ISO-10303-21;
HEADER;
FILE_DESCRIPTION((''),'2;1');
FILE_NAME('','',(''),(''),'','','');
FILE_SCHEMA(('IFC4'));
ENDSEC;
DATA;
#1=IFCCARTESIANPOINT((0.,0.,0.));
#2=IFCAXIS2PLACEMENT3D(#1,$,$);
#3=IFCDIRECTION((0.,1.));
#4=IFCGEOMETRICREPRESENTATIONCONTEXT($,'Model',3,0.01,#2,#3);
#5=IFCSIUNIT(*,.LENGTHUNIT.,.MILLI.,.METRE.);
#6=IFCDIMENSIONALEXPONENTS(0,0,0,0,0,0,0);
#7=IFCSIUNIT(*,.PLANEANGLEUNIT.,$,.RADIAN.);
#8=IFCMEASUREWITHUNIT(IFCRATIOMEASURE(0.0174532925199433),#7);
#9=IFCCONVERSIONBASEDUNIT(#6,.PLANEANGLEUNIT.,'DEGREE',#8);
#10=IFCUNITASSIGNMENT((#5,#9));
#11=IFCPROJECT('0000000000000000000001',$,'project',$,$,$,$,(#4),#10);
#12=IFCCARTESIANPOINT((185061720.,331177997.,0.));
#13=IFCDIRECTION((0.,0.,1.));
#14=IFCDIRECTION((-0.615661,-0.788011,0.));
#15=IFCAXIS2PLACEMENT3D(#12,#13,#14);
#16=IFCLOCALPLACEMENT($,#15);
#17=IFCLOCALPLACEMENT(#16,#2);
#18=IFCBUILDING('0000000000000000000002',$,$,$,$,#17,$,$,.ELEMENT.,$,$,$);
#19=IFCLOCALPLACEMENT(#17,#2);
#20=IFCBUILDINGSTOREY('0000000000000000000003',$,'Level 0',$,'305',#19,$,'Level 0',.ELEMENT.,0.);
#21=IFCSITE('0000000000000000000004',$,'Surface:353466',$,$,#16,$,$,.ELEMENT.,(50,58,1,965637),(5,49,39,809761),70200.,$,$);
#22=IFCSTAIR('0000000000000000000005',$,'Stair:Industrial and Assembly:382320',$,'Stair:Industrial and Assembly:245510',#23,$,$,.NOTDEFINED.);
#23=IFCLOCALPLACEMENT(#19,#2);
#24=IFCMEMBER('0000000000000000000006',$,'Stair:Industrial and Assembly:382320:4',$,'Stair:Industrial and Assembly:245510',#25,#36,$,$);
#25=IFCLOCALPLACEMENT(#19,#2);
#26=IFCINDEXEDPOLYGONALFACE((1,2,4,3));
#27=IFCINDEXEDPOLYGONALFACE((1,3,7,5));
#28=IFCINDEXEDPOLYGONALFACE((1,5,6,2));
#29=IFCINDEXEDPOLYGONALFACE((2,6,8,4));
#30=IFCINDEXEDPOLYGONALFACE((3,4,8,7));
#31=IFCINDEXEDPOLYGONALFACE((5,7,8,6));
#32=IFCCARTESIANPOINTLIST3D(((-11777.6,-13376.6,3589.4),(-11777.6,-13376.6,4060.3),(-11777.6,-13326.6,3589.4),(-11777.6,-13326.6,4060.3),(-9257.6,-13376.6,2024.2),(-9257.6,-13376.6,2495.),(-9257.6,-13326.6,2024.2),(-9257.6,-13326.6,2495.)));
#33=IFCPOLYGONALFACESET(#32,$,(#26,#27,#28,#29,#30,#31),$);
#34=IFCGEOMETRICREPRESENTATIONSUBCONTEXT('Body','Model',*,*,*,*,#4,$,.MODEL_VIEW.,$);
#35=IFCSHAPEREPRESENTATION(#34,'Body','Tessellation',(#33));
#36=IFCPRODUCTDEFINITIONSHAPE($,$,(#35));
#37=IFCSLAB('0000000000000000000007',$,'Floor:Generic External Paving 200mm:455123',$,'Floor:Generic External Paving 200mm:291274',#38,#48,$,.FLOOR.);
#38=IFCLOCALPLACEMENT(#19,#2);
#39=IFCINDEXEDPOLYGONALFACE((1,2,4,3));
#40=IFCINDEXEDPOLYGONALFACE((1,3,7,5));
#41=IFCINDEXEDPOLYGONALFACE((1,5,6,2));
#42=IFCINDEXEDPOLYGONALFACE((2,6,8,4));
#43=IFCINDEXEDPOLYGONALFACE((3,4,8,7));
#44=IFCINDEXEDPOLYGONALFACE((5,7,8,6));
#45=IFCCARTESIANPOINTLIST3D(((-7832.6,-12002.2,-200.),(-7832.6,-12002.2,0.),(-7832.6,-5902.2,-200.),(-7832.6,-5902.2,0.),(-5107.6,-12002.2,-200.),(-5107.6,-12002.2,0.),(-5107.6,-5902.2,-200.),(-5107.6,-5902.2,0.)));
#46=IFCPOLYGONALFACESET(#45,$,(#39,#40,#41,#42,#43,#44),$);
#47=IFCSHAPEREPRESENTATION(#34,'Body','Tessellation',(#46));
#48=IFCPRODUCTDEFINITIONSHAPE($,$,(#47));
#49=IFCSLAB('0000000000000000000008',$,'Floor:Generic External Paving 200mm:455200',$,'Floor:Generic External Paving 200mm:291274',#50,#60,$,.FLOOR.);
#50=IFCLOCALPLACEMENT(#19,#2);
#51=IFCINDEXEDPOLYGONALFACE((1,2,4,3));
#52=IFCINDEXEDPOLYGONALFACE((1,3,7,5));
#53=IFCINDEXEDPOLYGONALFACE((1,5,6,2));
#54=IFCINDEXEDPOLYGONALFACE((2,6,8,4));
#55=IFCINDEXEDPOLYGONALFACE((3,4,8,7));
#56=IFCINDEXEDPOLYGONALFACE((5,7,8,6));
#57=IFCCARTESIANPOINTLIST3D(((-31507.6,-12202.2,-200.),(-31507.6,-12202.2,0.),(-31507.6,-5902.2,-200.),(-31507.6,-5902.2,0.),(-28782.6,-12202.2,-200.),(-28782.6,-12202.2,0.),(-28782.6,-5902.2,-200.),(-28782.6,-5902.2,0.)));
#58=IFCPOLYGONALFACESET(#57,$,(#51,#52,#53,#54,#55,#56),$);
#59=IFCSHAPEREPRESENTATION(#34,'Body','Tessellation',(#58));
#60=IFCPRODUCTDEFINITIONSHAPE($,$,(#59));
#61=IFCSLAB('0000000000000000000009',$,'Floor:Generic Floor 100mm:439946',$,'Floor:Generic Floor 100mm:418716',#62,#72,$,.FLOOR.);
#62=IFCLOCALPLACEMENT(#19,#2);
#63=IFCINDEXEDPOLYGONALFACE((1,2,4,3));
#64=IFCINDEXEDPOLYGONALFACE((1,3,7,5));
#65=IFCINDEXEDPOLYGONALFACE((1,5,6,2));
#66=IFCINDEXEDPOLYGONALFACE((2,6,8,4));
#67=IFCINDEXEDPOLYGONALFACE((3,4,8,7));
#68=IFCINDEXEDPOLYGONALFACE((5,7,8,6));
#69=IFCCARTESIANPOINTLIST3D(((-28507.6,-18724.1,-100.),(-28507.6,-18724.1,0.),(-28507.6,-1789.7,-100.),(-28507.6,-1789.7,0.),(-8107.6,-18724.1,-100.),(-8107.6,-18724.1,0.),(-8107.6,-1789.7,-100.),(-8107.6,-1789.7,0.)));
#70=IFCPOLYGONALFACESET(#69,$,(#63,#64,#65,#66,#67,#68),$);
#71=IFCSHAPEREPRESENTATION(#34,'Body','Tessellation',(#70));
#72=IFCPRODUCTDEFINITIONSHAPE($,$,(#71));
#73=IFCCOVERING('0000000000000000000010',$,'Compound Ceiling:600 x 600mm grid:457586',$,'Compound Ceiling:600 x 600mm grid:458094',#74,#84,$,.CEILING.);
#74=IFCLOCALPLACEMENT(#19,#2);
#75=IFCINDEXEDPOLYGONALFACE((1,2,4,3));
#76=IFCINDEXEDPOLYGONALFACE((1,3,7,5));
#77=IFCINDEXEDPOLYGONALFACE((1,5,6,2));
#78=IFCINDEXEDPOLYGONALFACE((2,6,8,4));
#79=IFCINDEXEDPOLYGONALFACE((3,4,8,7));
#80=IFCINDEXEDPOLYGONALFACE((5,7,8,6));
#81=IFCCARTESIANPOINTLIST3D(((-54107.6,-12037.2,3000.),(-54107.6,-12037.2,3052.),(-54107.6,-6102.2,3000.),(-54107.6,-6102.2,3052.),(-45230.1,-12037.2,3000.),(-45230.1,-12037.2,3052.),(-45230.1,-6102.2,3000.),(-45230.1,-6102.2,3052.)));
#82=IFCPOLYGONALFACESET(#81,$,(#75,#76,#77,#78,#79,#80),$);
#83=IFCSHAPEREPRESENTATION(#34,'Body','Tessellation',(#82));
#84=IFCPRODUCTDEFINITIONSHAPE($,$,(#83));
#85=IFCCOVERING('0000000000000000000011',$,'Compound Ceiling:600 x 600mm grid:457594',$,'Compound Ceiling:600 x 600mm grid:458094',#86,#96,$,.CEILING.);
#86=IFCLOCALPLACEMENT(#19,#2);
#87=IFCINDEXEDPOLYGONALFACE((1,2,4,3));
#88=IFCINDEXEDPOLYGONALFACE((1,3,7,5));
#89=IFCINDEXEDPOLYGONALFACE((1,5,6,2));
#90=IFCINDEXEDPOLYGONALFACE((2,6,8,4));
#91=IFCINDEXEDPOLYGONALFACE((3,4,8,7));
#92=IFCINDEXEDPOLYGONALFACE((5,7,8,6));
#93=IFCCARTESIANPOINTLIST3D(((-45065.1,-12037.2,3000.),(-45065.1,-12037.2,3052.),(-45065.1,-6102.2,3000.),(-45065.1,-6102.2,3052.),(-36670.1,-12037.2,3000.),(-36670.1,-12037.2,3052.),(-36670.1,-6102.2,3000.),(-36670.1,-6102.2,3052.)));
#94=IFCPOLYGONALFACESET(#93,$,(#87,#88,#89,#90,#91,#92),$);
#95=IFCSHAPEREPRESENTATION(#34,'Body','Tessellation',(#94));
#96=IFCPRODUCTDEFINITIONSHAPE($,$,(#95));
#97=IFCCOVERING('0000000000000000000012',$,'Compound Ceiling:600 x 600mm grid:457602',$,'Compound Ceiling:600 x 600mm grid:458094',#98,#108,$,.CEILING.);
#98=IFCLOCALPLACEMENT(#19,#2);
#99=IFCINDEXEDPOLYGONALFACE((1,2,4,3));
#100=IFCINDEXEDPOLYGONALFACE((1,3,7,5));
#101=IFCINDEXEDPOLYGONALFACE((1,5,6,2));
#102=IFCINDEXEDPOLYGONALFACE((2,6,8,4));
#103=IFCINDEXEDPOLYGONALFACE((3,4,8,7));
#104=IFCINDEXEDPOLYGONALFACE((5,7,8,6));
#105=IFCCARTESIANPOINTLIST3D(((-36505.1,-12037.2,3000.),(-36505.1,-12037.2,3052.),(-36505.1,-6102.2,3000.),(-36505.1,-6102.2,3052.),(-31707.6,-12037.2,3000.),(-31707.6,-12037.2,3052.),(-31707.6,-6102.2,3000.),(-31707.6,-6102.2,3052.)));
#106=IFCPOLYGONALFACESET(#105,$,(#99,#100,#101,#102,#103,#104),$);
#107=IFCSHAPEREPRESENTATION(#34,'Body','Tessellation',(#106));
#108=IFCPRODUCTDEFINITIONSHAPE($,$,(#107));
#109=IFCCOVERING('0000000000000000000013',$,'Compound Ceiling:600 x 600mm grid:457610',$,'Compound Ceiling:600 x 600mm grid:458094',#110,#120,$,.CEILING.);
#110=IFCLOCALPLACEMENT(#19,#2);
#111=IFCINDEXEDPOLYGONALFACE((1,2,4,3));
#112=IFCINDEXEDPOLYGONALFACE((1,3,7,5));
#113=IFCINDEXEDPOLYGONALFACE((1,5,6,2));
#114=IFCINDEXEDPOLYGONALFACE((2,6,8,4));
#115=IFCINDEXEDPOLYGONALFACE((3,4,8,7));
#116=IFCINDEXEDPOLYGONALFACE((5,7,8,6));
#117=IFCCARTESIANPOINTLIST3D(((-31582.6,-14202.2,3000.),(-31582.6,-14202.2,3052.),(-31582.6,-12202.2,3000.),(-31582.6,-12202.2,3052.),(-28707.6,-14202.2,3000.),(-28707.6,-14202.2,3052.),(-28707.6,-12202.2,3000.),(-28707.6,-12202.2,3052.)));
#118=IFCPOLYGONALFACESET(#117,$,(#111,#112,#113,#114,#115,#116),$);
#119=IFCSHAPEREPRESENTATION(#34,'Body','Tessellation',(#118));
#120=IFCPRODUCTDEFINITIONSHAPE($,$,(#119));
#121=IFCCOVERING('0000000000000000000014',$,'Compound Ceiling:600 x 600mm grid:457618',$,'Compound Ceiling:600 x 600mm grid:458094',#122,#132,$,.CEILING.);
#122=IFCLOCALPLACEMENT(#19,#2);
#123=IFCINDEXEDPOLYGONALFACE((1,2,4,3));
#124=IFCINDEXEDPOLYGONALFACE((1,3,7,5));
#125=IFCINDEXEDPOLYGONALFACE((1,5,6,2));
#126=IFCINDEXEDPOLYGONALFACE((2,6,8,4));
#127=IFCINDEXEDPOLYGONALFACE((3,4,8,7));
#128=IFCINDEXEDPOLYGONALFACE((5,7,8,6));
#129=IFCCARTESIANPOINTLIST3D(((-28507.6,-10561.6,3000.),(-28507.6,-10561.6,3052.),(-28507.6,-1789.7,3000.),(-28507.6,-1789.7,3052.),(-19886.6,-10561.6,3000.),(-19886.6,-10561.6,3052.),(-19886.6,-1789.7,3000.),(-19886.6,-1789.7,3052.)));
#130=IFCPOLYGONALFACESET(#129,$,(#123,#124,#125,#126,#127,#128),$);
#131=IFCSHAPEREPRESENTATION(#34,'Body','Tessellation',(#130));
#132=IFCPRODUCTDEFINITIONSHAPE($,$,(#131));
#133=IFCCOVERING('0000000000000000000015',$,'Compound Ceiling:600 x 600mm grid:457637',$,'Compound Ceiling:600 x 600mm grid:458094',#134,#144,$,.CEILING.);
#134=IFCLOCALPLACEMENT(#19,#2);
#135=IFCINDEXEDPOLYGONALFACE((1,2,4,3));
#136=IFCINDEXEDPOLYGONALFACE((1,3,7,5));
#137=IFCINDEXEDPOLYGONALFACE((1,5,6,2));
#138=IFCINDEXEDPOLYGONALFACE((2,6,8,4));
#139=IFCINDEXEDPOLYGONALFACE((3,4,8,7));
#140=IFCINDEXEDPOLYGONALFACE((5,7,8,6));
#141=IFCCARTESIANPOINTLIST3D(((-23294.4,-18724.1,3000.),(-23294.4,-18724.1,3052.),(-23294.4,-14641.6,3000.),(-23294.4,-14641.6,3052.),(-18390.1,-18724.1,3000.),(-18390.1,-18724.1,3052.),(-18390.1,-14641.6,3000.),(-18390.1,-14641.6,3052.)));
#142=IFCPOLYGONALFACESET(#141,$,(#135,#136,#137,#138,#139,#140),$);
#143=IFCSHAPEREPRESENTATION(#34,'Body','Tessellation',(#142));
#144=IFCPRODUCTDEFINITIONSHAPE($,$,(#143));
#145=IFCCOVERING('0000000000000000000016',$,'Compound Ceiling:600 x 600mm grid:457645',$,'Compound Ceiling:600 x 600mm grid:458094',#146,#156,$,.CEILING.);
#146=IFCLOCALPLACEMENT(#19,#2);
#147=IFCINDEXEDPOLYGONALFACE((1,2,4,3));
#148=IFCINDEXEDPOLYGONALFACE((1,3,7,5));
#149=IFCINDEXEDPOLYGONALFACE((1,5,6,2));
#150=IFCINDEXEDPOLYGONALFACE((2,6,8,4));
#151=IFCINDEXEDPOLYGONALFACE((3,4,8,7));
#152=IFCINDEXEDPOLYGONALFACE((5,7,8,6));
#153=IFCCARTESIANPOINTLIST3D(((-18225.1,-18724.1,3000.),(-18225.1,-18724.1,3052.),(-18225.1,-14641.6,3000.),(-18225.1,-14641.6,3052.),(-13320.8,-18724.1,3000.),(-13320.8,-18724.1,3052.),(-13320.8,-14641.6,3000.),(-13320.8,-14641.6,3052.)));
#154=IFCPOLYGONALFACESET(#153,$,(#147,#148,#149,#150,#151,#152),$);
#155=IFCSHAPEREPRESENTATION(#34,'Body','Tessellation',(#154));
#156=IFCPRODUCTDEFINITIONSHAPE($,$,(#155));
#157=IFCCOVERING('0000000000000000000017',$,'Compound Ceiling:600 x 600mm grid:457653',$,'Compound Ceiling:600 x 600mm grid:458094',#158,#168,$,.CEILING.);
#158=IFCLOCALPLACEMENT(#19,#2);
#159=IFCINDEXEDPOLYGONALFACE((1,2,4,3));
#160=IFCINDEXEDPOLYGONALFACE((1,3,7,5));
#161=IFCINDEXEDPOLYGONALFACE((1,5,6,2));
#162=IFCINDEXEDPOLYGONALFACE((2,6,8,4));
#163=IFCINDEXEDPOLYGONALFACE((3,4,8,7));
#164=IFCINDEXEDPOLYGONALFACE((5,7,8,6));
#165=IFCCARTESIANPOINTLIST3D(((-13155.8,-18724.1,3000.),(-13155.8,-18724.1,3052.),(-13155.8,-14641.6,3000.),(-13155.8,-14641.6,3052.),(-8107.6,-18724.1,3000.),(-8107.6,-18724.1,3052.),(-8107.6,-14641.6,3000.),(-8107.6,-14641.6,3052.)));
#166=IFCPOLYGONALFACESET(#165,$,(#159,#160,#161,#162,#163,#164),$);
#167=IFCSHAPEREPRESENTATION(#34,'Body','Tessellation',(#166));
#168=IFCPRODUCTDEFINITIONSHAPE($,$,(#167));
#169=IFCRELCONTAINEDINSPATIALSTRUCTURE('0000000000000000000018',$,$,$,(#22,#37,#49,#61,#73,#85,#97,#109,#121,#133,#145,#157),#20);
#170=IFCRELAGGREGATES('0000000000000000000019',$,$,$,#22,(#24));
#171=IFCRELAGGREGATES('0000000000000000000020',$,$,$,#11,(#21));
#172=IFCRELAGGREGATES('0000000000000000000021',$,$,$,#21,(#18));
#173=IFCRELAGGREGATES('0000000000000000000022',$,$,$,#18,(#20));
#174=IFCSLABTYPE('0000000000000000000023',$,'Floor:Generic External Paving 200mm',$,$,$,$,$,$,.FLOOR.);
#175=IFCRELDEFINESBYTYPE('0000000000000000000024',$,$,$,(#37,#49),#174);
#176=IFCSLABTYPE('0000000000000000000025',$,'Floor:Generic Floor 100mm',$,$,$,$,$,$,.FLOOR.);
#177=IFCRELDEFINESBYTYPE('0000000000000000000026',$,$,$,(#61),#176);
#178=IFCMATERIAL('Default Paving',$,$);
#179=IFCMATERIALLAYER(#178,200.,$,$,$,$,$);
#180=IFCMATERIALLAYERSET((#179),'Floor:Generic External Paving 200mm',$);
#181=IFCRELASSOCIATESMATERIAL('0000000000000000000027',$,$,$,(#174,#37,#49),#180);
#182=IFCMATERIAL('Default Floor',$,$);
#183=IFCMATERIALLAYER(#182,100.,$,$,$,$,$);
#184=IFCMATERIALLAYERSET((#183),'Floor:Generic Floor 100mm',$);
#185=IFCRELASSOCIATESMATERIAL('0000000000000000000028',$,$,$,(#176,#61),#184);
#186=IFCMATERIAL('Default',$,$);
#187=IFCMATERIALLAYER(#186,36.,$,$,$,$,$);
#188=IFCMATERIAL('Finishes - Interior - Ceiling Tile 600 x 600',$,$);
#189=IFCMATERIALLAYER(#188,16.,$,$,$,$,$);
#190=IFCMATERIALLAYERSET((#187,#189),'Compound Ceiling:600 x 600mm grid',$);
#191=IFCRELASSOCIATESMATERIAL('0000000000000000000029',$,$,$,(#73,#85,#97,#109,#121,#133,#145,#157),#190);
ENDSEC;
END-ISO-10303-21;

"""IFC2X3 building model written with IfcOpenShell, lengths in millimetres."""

from ifc_helpers import new_model, entity, si_unit, converted_unit, direction, frame, frame_2d, origin, place, context, subcontext, project, spatial, polyline, rectangle, outline, extrude, material, layer, layer_set, layer_usage, type_object, element, aggregate, save


model = new_model("IFC2X3")

# Units and contexts
model_context = context("Model", 3, precision=0.01, world=origin(), true_north=direction((0.0, 1.0)))
body_context = subcontext(model_context, "Body", "Model", "MODEL_VIEW")
ifc_project = project(units=[si_unit("LENGTHUNIT", "METRE", prefix="MILLI"), converted_unit("PLANEANGLEUNIT", "DEGREE", entity("IfcRatioMeasure", 0.0174532925199433), si_unit("PLANEANGLEUNIT", "RADIAN"), dimensions=[0, 0, 0, 0, 0, 0, 0])], contexts=[model_context])

# Site, building, storey
site_placement = place(None, frame((185061720.0, 331177997.0, 0.0), z_axis=(0.0, 0.0, 1.0), x_axis=(-0.615661, -0.788011, 0.0)))
site = spatial("IfcSite", under=ifc_project, at=site_placement, Name="Surface:353466", CompositionType="ELEMENT", RefLatitude=(50, 58, 1, 965637), RefLongitude=(5, 49, 39, 809761), RefElevation=70200.0)
building_placement = place(site_placement, origin())
building = spatial("IfcBuilding", under=site, at=building_placement, CompositionType="ELEMENT")
storey_placement = place(building_placement, origin())
storey = spatial("IfcBuildingStorey", under=building, at=storey_placement, Name="Level 0", ObjectType="305", LongName="Level 0", CompositionType="ELEMENT", Elevation=0.0)

# Stair, member
stair_1_placement = place(storey_placement, origin())
stair_1 = element("IfcStair", 1, at=stair_1_placement, inside=storey, Name="Stair:Industrial and Assembly:382320", ObjectType="Stair:Industrial and Assembly:245510", ShapeType="NOTDEFINED")
member_placement = place(stair_1_placement, origin())
member = element("IfcMember", 2, at=member_placement, Name="Stair:Industrial and Assembly:382320:4", ObjectType="Stair:Industrial and Assembly:245510", context=body_context, shape_type="SweptSolid", body=[
    extrude(outline(polyline([(-1607.5, -200.0), (1359.0, -200.0), (1607.5, 200.0), (-1359.0, 200.0), (-1607.5, -200.0)])), frame((-10517.6, -13376.6, 3042.2), z_axis=(0.0, 1.0, 0.0), x_axis=(-0.849477, 0.0, 0.527626)), (0.0, 0.0, 1.0), 50.0),
])
aggregate(stair_1, [member])

# Slabs
ifc_material_1 = material(Name="Default Paving")
ifc_layer_1 = layer(ifc_material_1, 200.0)
ifc_layer_set_1 = layer_set([ifc_layer_1], Name="Floor:Generic External Paving 200mm")
ifc_layer_usage_1 = layer_usage(ifc_layer_set_1, "AXIS3", "POSITIVE", 0.0)
slab_type_1 = type_object("IfcSlabType", Name="Floor:Generic External Paving 200mm", PredefinedType="FLOOR", material=ifc_layer_set_1)
slab_1_placement = place(storey_placement, origin())
element("IfcSlab", 3, at=slab_1_placement, inside=storey, type_object=slab_type_1, material=ifc_layer_usage_1, Name="Floor:Generic External Paving 200mm:455123", ObjectType="Floor:Generic External Paving 200mm:291274", PredefinedType="FLOOR", context=body_context, shape_type="SweptSolid", body=[
    extrude(rectangle(XDim=6100.0, YDim=2725.0, at=frame_2d((0.0, 0.0), x_axis=(1.0, 0.0))), frame((-6470.1, -8952.2, 0.0), z_axis=(0.0, 0.0, -1.0), x_axis=(0.0, 1.0, 0.0)), (0.0, 0.0, 1.0), 200.0),
])
ifc_layer_usage_2 = layer_usage(ifc_layer_set_1, "AXIS3", "POSITIVE", 0.0)
slab_2_placement = place(storey_placement, origin())
element("IfcSlab", 4, at=slab_2_placement, inside=storey, type_object=slab_type_1, material=ifc_layer_usage_2, Name="Floor:Generic External Paving 200mm:455200", ObjectType="Floor:Generic External Paving 200mm:291274", PredefinedType="FLOOR", context=body_context, shape_type="SweptSolid", body=[
    extrude(rectangle(XDim=6300.0, YDim=2725.0, at=frame_2d((0.0, 0.0), x_axis=(1.0, 0.0))), frame((-30145.1, -9052.2, 0.0), z_axis=(0.0, 0.0, -1.0), x_axis=(0.0, 1.0, 0.0)), (0.0, 0.0, 1.0), 200.0),
])
ifc_material_2 = material(Name="Default Floor")
ifc_layer_2 = layer(ifc_material_2, 100.0)
ifc_layer_set_2 = layer_set([ifc_layer_2], Name="Floor:Generic Floor 100mm")
ifc_layer_usage_3 = layer_usage(ifc_layer_set_2, "AXIS3", "POSITIVE", 0.0)
slab_type_2 = type_object("IfcSlabType", Name="Floor:Generic Floor 100mm", PredefinedType="FLOOR", material=ifc_layer_set_2)
slab_3_placement = place(storey_placement, origin())
element("IfcSlab", 5, at=slab_3_placement, inside=storey, type_object=slab_type_2, material=ifc_layer_usage_3, Name="Floor:Generic Floor 100mm:439946", ObjectType="Floor:Generic Floor 100mm:418716", PredefinedType="FLOOR", context=body_context, shape_type="SweptSolid", body=[
    extrude(rectangle(XDim=16934.4, YDim=20400.0, at=frame_2d((0.0, 0.0), x_axis=(1.0, 0.0))), frame((-18307.6, -10256.9, 0.0), z_axis=(0.0, 0.0, -1.0), x_axis=(0.0, 1.0, 0.0)), (0.0, 0.0, 1.0), 100.0),
])

# Coverings
ifc_material_3 = material(Name="Default")
ifc_layer_3 = layer(ifc_material_3, 36.0)
ifc_material_4 = material(Name="Finishes - Interior - Ceiling Tile 600 x 600")
ifc_layer_4 = layer(ifc_material_4, 16.0)
ifc_layer_set_3 = layer_set([ifc_layer_3, ifc_layer_4], Name="Compound Ceiling:600 x 600mm grid")
ifc_layer_usage_4 = layer_usage(ifc_layer_set_3, "AXIS3", "POSITIVE", 0.0)
covering_1_placement = place(storey_placement, origin())
element("IfcCovering", 6, at=covering_1_placement, inside=storey, material=ifc_layer_usage_4, Name="Compound Ceiling:600 x 600mm grid:457586", ObjectType="Compound Ceiling:600 x 600mm grid:458094", PredefinedType="CEILING", context=body_context, shape_type="SweptSolid", body=[
    extrude(rectangle(XDim=8877.5, YDim=5935.0, at=frame_2d((0.0, 0.0), x_axis=(1.0, 0.0))), frame((-49668.8, -9069.7, 3000.0)), (0.0, 0.0, 1.0), 52.0),
])
ifc_layer_usage_5 = layer_usage(ifc_layer_set_3, "AXIS3", "POSITIVE", 0.0)
covering_2_placement = place(storey_placement, origin())
element("IfcCovering", 7, at=covering_2_placement, inside=storey, material=ifc_layer_usage_5, Name="Compound Ceiling:600 x 600mm grid:457594", ObjectType="Compound Ceiling:600 x 600mm grid:458094", PredefinedType="CEILING", context=body_context, shape_type="SweptSolid", body=[
    extrude(rectangle(XDim=8395.0, YDim=5935.0, at=frame_2d((0.0, 0.0), x_axis=(1.0, 0.0))), frame((-40867.6, -9069.7, 3000.0)), (0.0, 0.0, 1.0), 52.0),
])
ifc_layer_usage_6 = layer_usage(ifc_layer_set_3, "AXIS3", "POSITIVE", 0.0)
covering_3_placement = place(storey_placement, origin())
element("IfcCovering", 8, at=covering_3_placement, inside=storey, material=ifc_layer_usage_6, Name="Compound Ceiling:600 x 600mm grid:457602", ObjectType="Compound Ceiling:600 x 600mm grid:458094", PredefinedType="CEILING", context=body_context, shape_type="SweptSolid", body=[
    extrude(rectangle(XDim=5935.0, YDim=4797.5, at=frame_2d((0.0, 0.0), x_axis=(1.0, 0.0))), frame((-34106.3, -9069.7, 3000.0), z_axis=(0.0, 0.0, 1.0), x_axis=(0.0, -1.0, 0.0)), (0.0, 0.0, 1.0), 52.0),
])
ifc_layer_usage_7 = layer_usage(ifc_layer_set_3, "AXIS3", "POSITIVE", 0.0)
covering_4_placement = place(storey_placement, origin())
element("IfcCovering", 9, at=covering_4_placement, inside=storey, material=ifc_layer_usage_7, Name="Compound Ceiling:600 x 600mm grid:457610", ObjectType="Compound Ceiling:600 x 600mm grid:458094", PredefinedType="CEILING", context=body_context, shape_type="SweptSolid", body=[
    extrude(rectangle(XDim=2875.0, YDim=2000.0, at=frame_2d((0.0, 0.0), x_axis=(1.0, 0.0))), frame((-30145.1, -13202.2, 3000.0)), (0.0, 0.0, 1.0), 52.0),
])
ifc_layer_usage_8 = layer_usage(ifc_layer_set_3, "AXIS3", "POSITIVE", 0.0)
covering_5_placement = place(storey_placement, origin())
element("IfcCovering", 10, at=covering_5_placement, inside=storey, material=ifc_layer_usage_8, Name="Compound Ceiling:600 x 600mm grid:457618", ObjectType="Compound Ceiling:600 x 600mm grid:458094", PredefinedType="CEILING", context=body_context, shape_type="SweptSolid", body=[
    extrude(rectangle(XDim=8771.9, YDim=8621.0, at=frame_2d((0.0, 0.0), x_axis=(1.0, 0.0))), frame((-24197.1, -6175.7, 3000.0), z_axis=(0.0, 0.0, 1.0), x_axis=(0.0, 1.0, 0.0)), (0.0, 0.0, 1.0), 52.0),
])
ifc_layer_usage_9 = layer_usage(ifc_layer_set_3, "AXIS3", "POSITIVE", 0.0)
covering_6_placement = place(storey_placement, origin())
element("IfcCovering", 11, at=covering_6_placement, inside=storey, material=ifc_layer_usage_9, Name="Compound Ceiling:600 x 600mm grid:457637", ObjectType="Compound Ceiling:600 x 600mm grid:458094", PredefinedType="CEILING", context=body_context, shape_type="SweptSolid", body=[
    extrude(rectangle(XDim=4082.5, YDim=4904.3, at=frame_2d((0.0, 0.0), x_axis=(1.0, 0.0))), frame((-20842.2, -16682.9, 3000.0), z_axis=(0.0, 0.0, 1.0), x_axis=(0.0, 1.0, 0.0)), (0.0, 0.0, 1.0), 52.0),
])
ifc_layer_usage_10 = layer_usage(ifc_layer_set_3, "AXIS3", "POSITIVE", 0.0)
covering_7_placement = place(storey_placement, origin())
element("IfcCovering", 12, at=covering_7_placement, inside=storey, material=ifc_layer_usage_10, Name="Compound Ceiling:600 x 600mm grid:457645", ObjectType="Compound Ceiling:600 x 600mm grid:458094", PredefinedType="CEILING", context=body_context, shape_type="SweptSolid", body=[
    extrude(rectangle(XDim=4082.5, YDim=4904.3, at=frame_2d((0.0, 0.0), x_axis=(1.0, 0.0))), frame((-15772.9, -16682.9, 3000.0), z_axis=(0.0, 0.0, 1.0), x_axis=(0.0, 1.0, 0.0)), (0.0, 0.0, 1.0), 52.0),
])
ifc_layer_usage_11 = layer_usage(ifc_layer_set_3, "AXIS3", "POSITIVE", 0.0)
covering_8_placement = place(storey_placement, origin())
element("IfcCovering", 13, at=covering_8_placement, inside=storey, material=ifc_layer_usage_11, Name="Compound Ceiling:600 x 600mm grid:457653", ObjectType="Compound Ceiling:600 x 600mm grid:458094", PredefinedType="CEILING", context=body_context, shape_type="SweptSolid", body=[
    extrude(rectangle(XDim=5048.2, YDim=4082.5, at=frame_2d((0.0, 0.0), x_axis=(1.0, 0.0))), frame((-10631.7, -16682.9, 3000.0), z_axis=(0.0, 0.0, 1.0), x_axis=(-1.0, 0.0, 0.0)), (0.0, 0.0, 1.0), 52.0),
])

save(model, "model.ifc")
